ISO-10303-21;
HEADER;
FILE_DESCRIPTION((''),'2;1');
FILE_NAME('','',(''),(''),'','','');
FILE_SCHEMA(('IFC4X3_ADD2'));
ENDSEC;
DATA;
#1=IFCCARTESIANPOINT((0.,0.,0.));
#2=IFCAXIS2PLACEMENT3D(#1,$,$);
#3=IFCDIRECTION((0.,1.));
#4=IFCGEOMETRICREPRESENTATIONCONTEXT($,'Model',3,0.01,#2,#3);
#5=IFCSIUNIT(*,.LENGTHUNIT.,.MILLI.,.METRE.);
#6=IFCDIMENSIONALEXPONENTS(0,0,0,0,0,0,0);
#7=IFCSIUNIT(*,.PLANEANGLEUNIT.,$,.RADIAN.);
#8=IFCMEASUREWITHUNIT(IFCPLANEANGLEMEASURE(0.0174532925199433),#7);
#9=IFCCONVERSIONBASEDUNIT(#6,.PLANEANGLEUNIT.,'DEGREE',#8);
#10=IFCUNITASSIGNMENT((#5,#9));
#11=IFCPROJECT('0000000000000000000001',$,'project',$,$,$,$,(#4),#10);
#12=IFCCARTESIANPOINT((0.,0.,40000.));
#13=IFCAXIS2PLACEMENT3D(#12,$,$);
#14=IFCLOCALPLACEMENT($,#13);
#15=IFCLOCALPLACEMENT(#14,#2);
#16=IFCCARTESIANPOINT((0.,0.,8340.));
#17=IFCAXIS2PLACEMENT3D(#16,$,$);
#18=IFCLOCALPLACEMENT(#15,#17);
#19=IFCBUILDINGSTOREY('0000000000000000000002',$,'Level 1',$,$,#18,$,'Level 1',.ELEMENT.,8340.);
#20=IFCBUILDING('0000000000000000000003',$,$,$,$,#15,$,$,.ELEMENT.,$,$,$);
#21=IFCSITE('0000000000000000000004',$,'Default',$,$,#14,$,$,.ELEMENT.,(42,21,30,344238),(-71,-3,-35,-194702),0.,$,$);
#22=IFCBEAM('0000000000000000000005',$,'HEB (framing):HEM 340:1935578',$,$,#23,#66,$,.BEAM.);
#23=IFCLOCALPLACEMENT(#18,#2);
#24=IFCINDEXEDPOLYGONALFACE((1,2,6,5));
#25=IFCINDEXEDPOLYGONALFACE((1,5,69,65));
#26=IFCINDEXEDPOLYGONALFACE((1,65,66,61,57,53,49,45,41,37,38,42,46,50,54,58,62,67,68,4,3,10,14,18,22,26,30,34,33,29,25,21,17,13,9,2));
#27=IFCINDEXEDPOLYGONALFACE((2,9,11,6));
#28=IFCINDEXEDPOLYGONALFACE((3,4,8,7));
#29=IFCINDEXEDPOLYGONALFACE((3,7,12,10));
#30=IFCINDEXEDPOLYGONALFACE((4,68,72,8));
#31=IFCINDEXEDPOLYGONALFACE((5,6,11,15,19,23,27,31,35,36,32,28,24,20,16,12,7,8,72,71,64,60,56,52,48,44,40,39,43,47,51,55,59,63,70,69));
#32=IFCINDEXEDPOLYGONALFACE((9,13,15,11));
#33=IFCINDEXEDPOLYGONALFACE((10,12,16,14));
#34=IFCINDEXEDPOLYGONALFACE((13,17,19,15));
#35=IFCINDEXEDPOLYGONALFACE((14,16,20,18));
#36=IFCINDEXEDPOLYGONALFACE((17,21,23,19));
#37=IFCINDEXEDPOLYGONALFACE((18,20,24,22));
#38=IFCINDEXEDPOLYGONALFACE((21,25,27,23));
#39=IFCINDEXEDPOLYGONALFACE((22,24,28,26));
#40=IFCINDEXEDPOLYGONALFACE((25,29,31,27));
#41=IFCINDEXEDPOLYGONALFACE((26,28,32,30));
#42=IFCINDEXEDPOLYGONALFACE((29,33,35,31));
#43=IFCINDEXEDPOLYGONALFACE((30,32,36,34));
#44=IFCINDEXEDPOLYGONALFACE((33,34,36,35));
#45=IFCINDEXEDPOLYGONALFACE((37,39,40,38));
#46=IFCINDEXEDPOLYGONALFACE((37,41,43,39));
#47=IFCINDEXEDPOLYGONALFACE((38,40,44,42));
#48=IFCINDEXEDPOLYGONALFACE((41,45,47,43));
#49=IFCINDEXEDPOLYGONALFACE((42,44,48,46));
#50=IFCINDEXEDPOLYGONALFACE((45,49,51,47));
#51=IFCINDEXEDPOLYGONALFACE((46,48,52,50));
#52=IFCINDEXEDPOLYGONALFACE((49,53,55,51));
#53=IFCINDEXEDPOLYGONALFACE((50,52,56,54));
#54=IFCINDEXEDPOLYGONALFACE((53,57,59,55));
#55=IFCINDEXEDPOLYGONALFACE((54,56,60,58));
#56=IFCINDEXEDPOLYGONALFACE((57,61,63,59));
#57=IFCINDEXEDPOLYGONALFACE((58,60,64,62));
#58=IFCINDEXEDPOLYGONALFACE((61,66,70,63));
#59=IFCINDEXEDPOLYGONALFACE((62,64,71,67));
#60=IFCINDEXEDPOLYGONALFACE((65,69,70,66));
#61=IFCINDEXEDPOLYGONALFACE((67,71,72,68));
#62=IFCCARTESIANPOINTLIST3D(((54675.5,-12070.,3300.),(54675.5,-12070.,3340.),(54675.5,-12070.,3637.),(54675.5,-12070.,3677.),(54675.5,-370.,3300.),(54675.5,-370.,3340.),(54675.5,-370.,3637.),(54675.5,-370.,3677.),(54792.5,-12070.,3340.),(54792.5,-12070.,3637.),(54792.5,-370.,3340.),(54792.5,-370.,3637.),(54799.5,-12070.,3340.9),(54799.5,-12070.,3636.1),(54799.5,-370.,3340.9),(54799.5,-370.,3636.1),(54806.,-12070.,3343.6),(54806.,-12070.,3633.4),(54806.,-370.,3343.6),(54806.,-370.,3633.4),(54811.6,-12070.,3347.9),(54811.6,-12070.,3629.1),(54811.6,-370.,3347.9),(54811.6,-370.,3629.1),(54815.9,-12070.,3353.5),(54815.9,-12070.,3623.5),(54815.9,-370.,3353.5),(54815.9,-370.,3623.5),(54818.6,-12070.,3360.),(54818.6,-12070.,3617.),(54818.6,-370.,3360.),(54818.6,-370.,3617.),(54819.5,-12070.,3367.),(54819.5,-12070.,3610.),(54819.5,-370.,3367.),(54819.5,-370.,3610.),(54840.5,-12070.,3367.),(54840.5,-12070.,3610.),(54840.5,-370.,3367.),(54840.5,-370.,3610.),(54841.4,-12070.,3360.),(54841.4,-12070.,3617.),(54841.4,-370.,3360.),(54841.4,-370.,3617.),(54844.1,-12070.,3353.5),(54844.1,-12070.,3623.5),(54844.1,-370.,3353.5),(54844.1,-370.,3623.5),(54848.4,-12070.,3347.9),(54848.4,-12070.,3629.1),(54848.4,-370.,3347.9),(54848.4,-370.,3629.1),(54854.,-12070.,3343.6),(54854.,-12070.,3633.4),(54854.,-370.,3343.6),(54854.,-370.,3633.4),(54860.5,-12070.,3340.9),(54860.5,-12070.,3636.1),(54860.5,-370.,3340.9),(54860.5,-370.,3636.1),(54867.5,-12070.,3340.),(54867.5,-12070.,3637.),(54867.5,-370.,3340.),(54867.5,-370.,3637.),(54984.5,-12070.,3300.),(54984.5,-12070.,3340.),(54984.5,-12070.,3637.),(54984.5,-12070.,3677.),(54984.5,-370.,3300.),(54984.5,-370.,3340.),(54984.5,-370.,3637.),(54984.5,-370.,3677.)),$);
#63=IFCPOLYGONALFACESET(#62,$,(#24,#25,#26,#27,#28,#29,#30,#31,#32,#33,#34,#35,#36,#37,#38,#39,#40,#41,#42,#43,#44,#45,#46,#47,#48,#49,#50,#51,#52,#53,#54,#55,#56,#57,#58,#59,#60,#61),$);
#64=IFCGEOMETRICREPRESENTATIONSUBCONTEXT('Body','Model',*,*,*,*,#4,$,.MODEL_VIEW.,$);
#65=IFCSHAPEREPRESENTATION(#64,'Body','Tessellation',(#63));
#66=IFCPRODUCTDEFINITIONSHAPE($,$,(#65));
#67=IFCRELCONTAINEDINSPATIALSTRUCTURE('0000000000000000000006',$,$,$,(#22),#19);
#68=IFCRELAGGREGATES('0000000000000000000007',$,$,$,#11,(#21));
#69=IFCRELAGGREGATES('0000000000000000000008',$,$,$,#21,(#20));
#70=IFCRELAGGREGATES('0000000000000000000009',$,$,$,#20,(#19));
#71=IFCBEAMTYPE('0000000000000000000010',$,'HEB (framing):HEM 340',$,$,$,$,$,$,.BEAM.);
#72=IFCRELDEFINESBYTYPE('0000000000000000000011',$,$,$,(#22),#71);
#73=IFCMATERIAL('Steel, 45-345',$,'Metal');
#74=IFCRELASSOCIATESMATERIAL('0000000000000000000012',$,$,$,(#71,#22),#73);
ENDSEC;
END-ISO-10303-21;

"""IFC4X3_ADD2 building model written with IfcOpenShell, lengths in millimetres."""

from ifc_helpers import new_model, entity, si_unit, converted_unit, direction, frame, frame_2d, origin, place, context, subcontext, project, spatial, polyline, circle_curve, parameter, trimmed, segment, composite_curve, outline, extrude, source, transform, mapped, material, material_profile, profile_set, profile_usage, type_object, type_shapes, element, save


model = new_model("IFC4X3_ADD2")

# Units and contexts
model_context = context("Model", 3, precision=0.01, world=origin(), true_north=direction((0.0, 1.0)))
body_context = subcontext(model_context, "Body", "Model", "MODEL_VIEW")
ifc_project = project(units=[si_unit("LENGTHUNIT", "METRE", prefix="MILLI"), converted_unit("PLANEANGLEUNIT", "DEGREE", entity("IfcPlaneAngleMeasure", 0.0174532925199433), si_unit("PLANEANGLEUNIT", "RADIAN"), dimensions=[0, 0, 0, 0, 0, 0, 0])], contexts=[model_context])

# Site, building, storey
site_placement = place(None, frame((0.0, 0.0, 40000.0)))
site = spatial("IfcSite", under=ifc_project, at=site_placement, Name="Default", CompositionType="ELEMENT", RefLatitude=(42, 21, 30, 344238), RefLongitude=(-71, -3, -35, -194702), RefElevation=0.0)
building_placement = place(site_placement, origin())
building = spatial("IfcBuilding", under=site, at=building_placement, CompositionType="ELEMENT")
storey_placement = place(building_placement, frame((0.0, 0.0, 8340.0)))
storey = spatial("IfcBuildingStorey", under=building, at=storey_placement, Name="Level 1", LongName="Level 1", CompositionType="ELEMENT", Elevation=8340.0)

# Shared definitions
ifc_material = material(Name="Steel, 45-345", Category="Metal")

# Beam
ifc_material_profile_1 = material_profile(ifc_material, outline(composite_curve([segment(polyline([(-154.5, -148.5), (-154.5, -188.5)]), True, "CONTINUOUS"), segment(polyline([(-154.5, -188.5), (154.5, -188.5)]), True, "CONTINUOUS"), segment(polyline([(154.5, -188.5), (154.5, -148.5)]), True, "CONTINUOUS"), segment(polyline([(154.5, -148.5), (37.5, -148.5)]), True, "CONTINUOUS"), segment(trimmed(circle_curve(frame_2d((37.5, -121.5), x_axis=(1.0, 0.0)), 27.0), [parameter(180.0)], [parameter(270.0)], True, "PARAMETER"), False, "CONTINUOUS"), segment(polyline([(10.5, -121.5), (10.5, 121.5)]), True, "CONTINUOUS"), segment(trimmed(circle_curve(frame_2d((37.5, 121.5), x_axis=(1.0, 0.0)), 27.0), [parameter(90.0)], [parameter(180.0)], True, "PARAMETER"), False, "CONTINUOUS"), segment(polyline([(37.5, 148.5), (154.5, 148.5)]), True, "CONTINUOUS"), segment(polyline([(154.5, 148.5), (154.5, 188.5)]), True, "CONTINUOUS"), segment(polyline([(154.5, 188.5), (-154.5, 188.5)]), True, "CONTINUOUS"), segment(polyline([(-154.5, 188.5), (-154.5, 148.5)]), True, "CONTINUOUS"), segment(polyline([(-154.5, 148.5), (-37.5, 148.5)]), True, "CONTINUOUS"), segment(trimmed(circle_curve(frame_2d((-37.5, 121.5), x_axis=(1.0, 0.0)), 27.0), [parameter(360.0)], [parameter(90.0)], True, "PARAMETER"), False, "CONTINUOUS"), segment(polyline([(-10.5, 121.5), (-10.5, -121.5)]), True, "CONTINUOUS"), segment(trimmed(circle_curve(frame_2d((-37.5, -121.5), x_axis=(1.0, 0.0)), 27.0), [parameter(270.0)], [parameter(0.0)], True, "PARAMETER"), False, "CONTINUOUS"), segment(polyline([(-37.5, -148.5), (-154.5, -148.5)]), True, "CONTINUOUS")], self_intersect=False)), Name="HEM 340")
ifc_profile_set_1 = profile_set([ifc_material_profile_1], Name="HEM 340")
ifc_profile_usage_1 = profile_usage(ifc_profile_set_1, cardinal=8)
beam_type_1 = type_object("IfcBeamType", Name="HEB (framing):HEM 340", PredefinedType="BEAM", material=ifc_profile_set_1)
shared_shape_1 = source(origin(), body_context, "Body", "SweptSolid", [
    extrude(outline(composite_curve([segment(polyline([(-154.5, -148.5), (-154.5, -188.5)]), True, "CONTINUOUS"), segment(polyline([(-154.5, -188.5), (154.5, -188.5)]), True, "CONTINUOUS"), segment(polyline([(154.5, -188.5), (154.5, -148.5)]), True, "CONTINUOUS"), segment(polyline([(154.5, -148.5), (37.5, -148.5)]), True, "CONTINUOUS"), segment(trimmed(circle_curve(frame_2d((37.5, -121.5), x_axis=(1.0, 0.0)), 27.0), [parameter(180.0)], [parameter(270.0)], True, "PARAMETER"), False, "CONTINUOUS"), segment(polyline([(10.5, -121.5), (10.5, 121.5)]), True, "CONTINUOUS"), segment(trimmed(circle_curve(frame_2d((37.5, 121.5), x_axis=(1.0, 0.0)), 27.0), [parameter(90.0)], [parameter(180.0)], True, "PARAMETER"), False, "CONTINUOUS"), segment(polyline([(37.5, 148.5), (154.5, 148.5)]), True, "CONTINUOUS"), segment(polyline([(154.5, 148.5), (154.5, 188.5)]), True, "CONTINUOUS"), segment(polyline([(154.5, 188.5), (-154.5, 188.5)]), True, "CONTINUOUS"), segment(polyline([(-154.5, 188.5), (-154.5, 148.5)]), True, "CONTINUOUS"), segment(polyline([(-154.5, 148.5), (-37.5, 148.5)]), True, "CONTINUOUS"), segment(trimmed(circle_curve(frame_2d((-37.5, 121.5), x_axis=(1.0, 0.0)), 27.0), [parameter(360.0)], [parameter(90.0)], True, "PARAMETER"), False, "CONTINUOUS"), segment(polyline([(-10.5, 121.5), (-10.5, -121.5)]), True, "CONTINUOUS"), segment(trimmed(circle_curve(frame_2d((-37.5, -121.5), x_axis=(1.0, 0.0)), 27.0), [parameter(270.0)], [parameter(0.0)], True, "PARAMETER"), False, "CONTINUOUS"), segment(polyline([(-37.5, -148.5), (-154.5, -148.5)]), True, "CONTINUOUS")], self_intersect=False)), frame((-5850.0, 0.0, 0.0), z_axis=(-1.0, 0.0, 0.0), x_axis=(0.0, -1.0, 0.0)), (0.0, 0.0, -1.0), 11700.0),
])
type_shapes(beam_type_1, [shared_shape_1])
beam_1_placement = place(storey_placement, frame((54830.0, -6220.0, 3488.5), z_axis=(0.0, 0.0, 1.0), x_axis=(0.0, -1.0, 0.0)))
element("IfcBeam", 1, at=beam_1_placement, inside=storey, type_object=beam_type_1, material=ifc_profile_usage_1, Name="HEB (framing):HEM 340:1935578", PredefinedType="BEAM", context=body_context, shape_type="MappedRepresentation", body=[
    mapped(shared_shape_1, transform((0.0, 0.0, 0.0), scale=1.0)),
])

save(model, "model.ifc")
